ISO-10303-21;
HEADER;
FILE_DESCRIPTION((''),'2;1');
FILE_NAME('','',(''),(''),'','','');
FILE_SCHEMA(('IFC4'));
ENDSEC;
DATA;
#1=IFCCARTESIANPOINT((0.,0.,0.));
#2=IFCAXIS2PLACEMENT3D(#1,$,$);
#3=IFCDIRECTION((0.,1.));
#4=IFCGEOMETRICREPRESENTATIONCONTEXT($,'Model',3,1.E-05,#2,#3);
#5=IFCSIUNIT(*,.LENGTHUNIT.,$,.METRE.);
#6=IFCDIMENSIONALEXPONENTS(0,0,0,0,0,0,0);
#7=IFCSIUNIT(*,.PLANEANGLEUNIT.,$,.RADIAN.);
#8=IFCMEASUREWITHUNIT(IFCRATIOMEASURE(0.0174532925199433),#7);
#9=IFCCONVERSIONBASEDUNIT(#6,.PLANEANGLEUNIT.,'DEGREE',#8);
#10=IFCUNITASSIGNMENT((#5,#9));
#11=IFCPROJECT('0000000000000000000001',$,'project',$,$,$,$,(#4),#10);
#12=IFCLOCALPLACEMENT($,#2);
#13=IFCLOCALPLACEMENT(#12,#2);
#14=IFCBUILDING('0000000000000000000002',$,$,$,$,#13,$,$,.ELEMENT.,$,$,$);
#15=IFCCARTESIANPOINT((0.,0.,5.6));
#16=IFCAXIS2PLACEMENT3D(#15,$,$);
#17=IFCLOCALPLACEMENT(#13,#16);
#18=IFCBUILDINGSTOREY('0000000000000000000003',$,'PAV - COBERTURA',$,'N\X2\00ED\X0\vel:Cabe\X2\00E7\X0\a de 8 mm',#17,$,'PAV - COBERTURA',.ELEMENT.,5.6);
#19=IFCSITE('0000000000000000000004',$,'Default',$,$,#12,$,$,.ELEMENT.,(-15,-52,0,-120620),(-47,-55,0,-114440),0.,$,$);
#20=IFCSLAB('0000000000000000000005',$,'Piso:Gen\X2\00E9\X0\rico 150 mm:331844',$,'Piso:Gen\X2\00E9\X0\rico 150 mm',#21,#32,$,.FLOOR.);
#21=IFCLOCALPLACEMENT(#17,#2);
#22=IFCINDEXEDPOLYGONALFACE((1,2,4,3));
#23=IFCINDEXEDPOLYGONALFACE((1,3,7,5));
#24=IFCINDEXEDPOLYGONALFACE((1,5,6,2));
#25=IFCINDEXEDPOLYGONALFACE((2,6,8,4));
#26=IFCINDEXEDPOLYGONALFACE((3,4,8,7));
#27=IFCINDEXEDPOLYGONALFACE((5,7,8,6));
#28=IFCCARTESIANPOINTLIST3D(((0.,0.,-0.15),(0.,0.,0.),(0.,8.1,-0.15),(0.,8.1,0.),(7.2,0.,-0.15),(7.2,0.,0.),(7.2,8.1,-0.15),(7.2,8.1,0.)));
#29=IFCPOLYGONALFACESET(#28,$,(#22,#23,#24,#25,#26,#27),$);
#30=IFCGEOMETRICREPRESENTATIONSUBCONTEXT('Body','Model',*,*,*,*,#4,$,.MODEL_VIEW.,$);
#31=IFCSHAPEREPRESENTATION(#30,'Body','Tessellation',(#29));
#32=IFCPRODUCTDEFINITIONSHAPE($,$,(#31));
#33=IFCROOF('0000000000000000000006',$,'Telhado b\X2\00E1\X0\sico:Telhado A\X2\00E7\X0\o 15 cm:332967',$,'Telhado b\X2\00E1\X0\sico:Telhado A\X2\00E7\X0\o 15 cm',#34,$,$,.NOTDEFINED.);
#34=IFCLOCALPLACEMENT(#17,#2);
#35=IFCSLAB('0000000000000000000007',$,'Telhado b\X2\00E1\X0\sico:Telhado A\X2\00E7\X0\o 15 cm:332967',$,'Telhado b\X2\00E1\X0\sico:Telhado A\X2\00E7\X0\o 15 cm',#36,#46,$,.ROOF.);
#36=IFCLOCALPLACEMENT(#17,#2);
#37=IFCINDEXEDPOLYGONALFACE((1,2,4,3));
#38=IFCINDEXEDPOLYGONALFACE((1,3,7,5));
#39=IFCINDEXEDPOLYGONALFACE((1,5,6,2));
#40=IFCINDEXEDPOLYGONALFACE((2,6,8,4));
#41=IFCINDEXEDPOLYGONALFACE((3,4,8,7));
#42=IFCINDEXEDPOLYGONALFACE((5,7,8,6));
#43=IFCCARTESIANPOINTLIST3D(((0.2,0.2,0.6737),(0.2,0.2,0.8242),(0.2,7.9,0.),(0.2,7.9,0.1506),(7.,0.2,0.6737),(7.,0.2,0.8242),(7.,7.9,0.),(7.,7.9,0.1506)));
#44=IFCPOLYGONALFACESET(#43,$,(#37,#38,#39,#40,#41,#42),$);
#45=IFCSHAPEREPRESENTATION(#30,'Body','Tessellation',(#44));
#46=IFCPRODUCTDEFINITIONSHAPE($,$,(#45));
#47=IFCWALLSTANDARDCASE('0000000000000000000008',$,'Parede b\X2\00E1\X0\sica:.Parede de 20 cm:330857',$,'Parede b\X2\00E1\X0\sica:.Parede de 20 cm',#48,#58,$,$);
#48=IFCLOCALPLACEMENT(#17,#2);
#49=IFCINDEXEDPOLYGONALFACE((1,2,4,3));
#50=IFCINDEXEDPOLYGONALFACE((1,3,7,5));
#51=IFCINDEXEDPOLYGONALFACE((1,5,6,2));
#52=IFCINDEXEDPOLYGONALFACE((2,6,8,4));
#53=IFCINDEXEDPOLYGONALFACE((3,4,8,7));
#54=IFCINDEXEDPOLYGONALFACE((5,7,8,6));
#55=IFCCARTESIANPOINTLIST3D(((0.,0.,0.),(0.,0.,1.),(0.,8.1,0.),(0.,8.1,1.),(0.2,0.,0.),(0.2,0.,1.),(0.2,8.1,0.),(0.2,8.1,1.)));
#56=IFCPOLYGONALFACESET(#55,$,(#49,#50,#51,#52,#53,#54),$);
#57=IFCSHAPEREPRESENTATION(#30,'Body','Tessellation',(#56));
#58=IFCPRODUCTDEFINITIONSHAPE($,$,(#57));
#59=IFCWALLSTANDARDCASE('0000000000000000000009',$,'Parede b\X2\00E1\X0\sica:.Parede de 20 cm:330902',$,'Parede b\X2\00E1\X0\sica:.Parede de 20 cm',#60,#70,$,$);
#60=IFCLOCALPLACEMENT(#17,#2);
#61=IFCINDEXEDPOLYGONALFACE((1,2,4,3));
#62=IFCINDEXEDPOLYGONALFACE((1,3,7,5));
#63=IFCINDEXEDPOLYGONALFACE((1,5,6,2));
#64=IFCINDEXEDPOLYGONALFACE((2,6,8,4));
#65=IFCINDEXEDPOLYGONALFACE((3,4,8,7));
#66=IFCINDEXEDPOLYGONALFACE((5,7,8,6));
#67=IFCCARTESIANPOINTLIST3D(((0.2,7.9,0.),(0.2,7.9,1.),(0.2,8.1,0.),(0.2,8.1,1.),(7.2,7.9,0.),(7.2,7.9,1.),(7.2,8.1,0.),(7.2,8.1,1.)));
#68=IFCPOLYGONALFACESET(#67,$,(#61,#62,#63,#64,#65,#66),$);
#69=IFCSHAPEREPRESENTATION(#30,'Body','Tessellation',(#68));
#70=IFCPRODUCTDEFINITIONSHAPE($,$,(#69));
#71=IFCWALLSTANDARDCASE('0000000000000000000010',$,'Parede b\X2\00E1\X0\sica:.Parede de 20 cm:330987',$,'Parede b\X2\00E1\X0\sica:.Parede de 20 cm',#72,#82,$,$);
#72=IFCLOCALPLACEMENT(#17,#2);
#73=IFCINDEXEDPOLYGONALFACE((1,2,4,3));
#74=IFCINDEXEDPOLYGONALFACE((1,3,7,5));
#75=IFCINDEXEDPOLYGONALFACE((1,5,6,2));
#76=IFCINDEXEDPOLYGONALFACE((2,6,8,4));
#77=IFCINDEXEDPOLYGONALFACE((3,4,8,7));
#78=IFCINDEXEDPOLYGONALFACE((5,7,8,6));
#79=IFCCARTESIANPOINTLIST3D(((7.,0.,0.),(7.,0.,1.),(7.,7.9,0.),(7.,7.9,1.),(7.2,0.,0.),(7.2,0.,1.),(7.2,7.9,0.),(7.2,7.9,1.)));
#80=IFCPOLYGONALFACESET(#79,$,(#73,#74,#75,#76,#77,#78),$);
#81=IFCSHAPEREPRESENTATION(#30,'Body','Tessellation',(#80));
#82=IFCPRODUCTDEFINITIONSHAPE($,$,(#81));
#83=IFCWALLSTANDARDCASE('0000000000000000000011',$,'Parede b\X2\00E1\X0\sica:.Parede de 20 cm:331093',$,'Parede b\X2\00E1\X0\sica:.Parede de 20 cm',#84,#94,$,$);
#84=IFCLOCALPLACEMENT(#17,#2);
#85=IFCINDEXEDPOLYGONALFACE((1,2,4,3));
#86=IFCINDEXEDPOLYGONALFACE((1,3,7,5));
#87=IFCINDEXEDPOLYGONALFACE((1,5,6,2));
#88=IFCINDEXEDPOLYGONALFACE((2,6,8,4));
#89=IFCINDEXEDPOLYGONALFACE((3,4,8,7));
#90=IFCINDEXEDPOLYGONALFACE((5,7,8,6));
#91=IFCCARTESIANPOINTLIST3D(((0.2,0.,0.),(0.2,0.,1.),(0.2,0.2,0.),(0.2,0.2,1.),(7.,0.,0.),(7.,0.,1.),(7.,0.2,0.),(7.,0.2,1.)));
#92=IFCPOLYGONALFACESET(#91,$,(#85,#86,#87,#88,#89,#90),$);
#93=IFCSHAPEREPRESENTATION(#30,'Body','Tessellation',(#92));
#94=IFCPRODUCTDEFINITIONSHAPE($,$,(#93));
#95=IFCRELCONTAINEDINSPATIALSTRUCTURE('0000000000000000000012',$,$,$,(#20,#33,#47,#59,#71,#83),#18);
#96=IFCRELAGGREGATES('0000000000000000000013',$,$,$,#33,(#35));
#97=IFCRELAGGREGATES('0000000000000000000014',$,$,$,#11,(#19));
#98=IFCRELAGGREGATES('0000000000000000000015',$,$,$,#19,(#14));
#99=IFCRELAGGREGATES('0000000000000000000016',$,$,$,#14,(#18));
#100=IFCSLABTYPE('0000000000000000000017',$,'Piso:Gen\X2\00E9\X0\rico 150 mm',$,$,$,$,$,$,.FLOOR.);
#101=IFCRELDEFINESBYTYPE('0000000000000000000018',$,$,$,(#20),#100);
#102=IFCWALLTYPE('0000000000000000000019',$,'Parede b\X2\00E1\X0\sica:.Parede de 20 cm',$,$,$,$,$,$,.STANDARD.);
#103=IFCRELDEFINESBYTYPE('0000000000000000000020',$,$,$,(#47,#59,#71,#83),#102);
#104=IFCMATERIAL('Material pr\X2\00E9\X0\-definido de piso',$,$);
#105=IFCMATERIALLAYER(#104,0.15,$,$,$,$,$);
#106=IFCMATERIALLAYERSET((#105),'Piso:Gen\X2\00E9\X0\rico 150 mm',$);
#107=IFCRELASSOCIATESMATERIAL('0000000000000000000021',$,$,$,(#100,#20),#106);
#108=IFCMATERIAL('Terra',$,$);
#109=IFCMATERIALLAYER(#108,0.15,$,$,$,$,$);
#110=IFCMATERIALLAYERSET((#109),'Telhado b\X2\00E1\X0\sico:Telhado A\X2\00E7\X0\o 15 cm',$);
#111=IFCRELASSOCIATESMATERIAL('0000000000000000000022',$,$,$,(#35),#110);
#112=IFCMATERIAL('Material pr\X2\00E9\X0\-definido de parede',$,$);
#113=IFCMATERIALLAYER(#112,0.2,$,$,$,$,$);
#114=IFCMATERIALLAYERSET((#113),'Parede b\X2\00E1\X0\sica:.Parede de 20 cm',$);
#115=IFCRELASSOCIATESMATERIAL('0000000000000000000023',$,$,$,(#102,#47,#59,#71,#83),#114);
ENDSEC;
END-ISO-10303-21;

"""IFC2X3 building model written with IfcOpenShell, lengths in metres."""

from ifc_helpers import new_model, entity, si_unit, converted_unit, direction, frame, frame_2d, origin, origin_2d_with_axis, place, context, subcontext, project, spatial, rectangle, extrude, material, layer, layer_set, layer_usage, type_object, element, aggregate, save


model = new_model("IFC2X3")

# Units and contexts
model_context = context("Model", 3, precision=1e-05, world=origin(), true_north=direction((0.0, 1.0)))
body_context = subcontext(model_context, "Body", "Model", "MODEL_VIEW")
ifc_project = project(units=[si_unit("LENGTHUNIT", "METRE"), converted_unit("PLANEANGLEUNIT", "DEGREE", entity("IfcRatioMeasure", 0.0174532925199433), si_unit("PLANEANGLEUNIT", "RADIAN"), dimensions=[0, 0, 0, 0, 0, 0, 0])], contexts=[model_context])

# Site, building, storey
site_placement = place(None, origin())
site = spatial("IfcSite", under=ifc_project, at=site_placement, Name="Default", CompositionType="ELEMENT", RefLatitude=(-15, -52, 0, -120620), RefLongitude=(-47, -55, 0, -114440), RefElevation=0.0)
building_placement = place(site_placement, origin())
building = spatial("IfcBuilding", under=site, at=building_placement, CompositionType="ELEMENT")
storey_placement = place(building_placement, frame((0.0, 0.0, 5.6)))
storey = spatial("IfcBuildingStorey", under=building, at=storey_placement, Name="PAV - COBERTURA", ObjectType="Nível:Cabeça de 8 mm", LongName="PAV - COBERTURA", CompositionType="ELEMENT", Elevation=5.6)

# Slab
ifc_material_1 = material(Name="Material pré-definido de piso")
ifc_layer_1 = layer(ifc_material_1, 0.15)
ifc_layer_set_1 = layer_set([ifc_layer_1], Name="Piso:Genérico 150 mm")
ifc_layer_usage_1 = layer_usage(ifc_layer_set_1, "AXIS3", "POSITIVE", 0.0)
slab_type = type_object("IfcSlabType", Name="Piso:Genérico 150 mm", PredefinedType="FLOOR", material=ifc_layer_set_1)
slab_1_placement = place(storey_placement, origin())
element("IfcSlab", 1, at=slab_1_placement, inside=storey, type_object=slab_type, material=ifc_layer_usage_1, Name="Piso:Genérico 150 mm:331844", ObjectType="Piso:Genérico 150 mm", PredefinedType="FLOOR", context=body_context, shape_type="SweptSolid", body=[
    extrude(rectangle(XDim=8.1, YDim=7.2, at=frame_2d((0.0, 0.0), x_axis=(1.0, 0.0))), frame((3.6, 4.05, 0.0), z_axis=(0.0, 0.0, -1.0), x_axis=(0.0, 1.0, 0.0)), (0.0, 0.0, 1.0), 0.15),
])

# Roof, slab
roof_placement = place(storey_placement, frame((0.2, 0.2, 0.0)))
roof = element("IfcRoof", 2, at=roof_placement, inside=storey, Name="Telhado básico:Telhado Aço 15 cm:332967", ObjectType="Telhado básico:Telhado Aço 15 cm", ShapeType="NOTDEFINED")
ifc_material_2 = material(Name="Terra")
ifc_layer_2 = layer(ifc_material_2, 0.15)
ifc_layer_set_2 = layer_set([ifc_layer_2], Name="Telhado básico:Telhado Aço 15 cm")
slab_2_placement = place(roof_placement, origin())
slab_2 = element("IfcSlab", 3, at=slab_2_placement, material=ifc_layer_set_2, Name="Telhado básico:Telhado Aço 15 cm:332967", ObjectType="Telhado básico:Telhado Aço 15 cm", PredefinedType="ROOF", context=body_context, shape_type="SweptSolid", body=[
    extrude(rectangle(XDim=6.8, YDim=7.7294, at=origin_2d_with_axis()), frame((3.4, 3.85, 0.3368), z_axis=(0.0, 0.087156, 0.996195), x_axis=(1.0, 0.0, 0.0)), (0.0, -0.087156, 0.996195), 0.1506),
])
aggregate(roof, [slab_2])

# Walls
ifc_material_3 = material(Name="Material pré-definido de parede")
ifc_layer_3 = layer(ifc_material_3, 0.2)
ifc_layer_set_3 = layer_set([ifc_layer_3], Name="Parede básica:.Parede de 20 cm")
ifc_layer_usage_2 = layer_usage(ifc_layer_set_3, "AXIS2", "NEGATIVE", 0.1)
wall_type = type_object("IfcWallType", Name="Parede básica:.Parede de 20 cm", PredefinedType="STANDARD", material=ifc_layer_set_3)
wall_1_placement = place(storey_placement, frame((0.1, 0.0, 0.0), z_axis=(0.0, 0.0, 1.0), x_axis=(0.0, 1.0, 0.0)))
element("IfcWallStandardCase", 4, at=wall_1_placement, inside=storey, type_object=wall_type, material=ifc_layer_usage_2, Name="Parede básica:.Parede de 20 cm:330857", ObjectType="Parede básica:.Parede de 20 cm", context=body_context, shape_type="SweptSolid", body=[
    extrude(rectangle(XDim=8.1, YDim=0.2, at=frame_2d((4.05, 0.0), x_axis=(-1.0, 0.0))), origin(), (0.0, 0.0, 1.0), 1.0),
])
ifc_layer_usage_3 = layer_usage(ifc_layer_set_3, "AXIS2", "NEGATIVE", 0.1)
wall_2_placement = place(storey_placement, frame((0.2, 8.0, 0.0)))
element("IfcWallStandardCase", 5, at=wall_2_placement, inside=storey, type_object=wall_type, material=ifc_layer_usage_3, Name="Parede básica:.Parede de 20 cm:330902", ObjectType="Parede básica:.Parede de 20 cm", context=body_context, shape_type="SweptSolid", body=[
    extrude(rectangle(XDim=7.0, YDim=0.2, at=frame_2d((3.5, 0.0), x_axis=(-1.0, 0.0))), origin(), (0.0, 0.0, 1.0), 1.0),
])
ifc_layer_usage_4 = layer_usage(ifc_layer_set_3, "AXIS2", "NEGATIVE", 0.1)
wall_3_placement = place(storey_placement, frame((7.1, 7.9, 0.0), z_axis=(0.0, 0.0, 1.0), x_axis=(0.0, -1.0, 0.0)))
element("IfcWallStandardCase", 6, at=wall_3_placement, inside=storey, type_object=wall_type, material=ifc_layer_usage_4, Name="Parede básica:.Parede de 20 cm:330987", ObjectType="Parede básica:.Parede de 20 cm", context=body_context, shape_type="SweptSolid", body=[
    extrude(rectangle(XDim=7.9, YDim=0.2, at=frame_2d((3.95, 0.0), x_axis=(-1.0, 0.0))), origin(), (0.0, 0.0, 1.0), 1.0),
])
ifc_layer_usage_5 = layer_usage(ifc_layer_set_3, "AXIS2", "NEGATIVE", 0.1)
wall_4_placement = place(storey_placement, frame((7.0, 0.1, 0.0), z_axis=(0.0, 0.0, 1.0), x_axis=(-1.0, 0.0, 0.0)))
element("IfcWallStandardCase", 7, at=wall_4_placement, inside=storey, type_object=wall_type, material=ifc_layer_usage_5, Name="Parede básica:.Parede de 20 cm:331093", ObjectType="Parede básica:.Parede de 20 cm", context=body_context, shape_type="SweptSolid", body=[
    extrude(rectangle(XDim=6.8, YDim=0.2, at=frame_2d((3.4, 0.0), x_axis=(-1.0, 0.0))), origin(), (0.0, 0.0, 1.0), 1.0),
])

save(model, "model.ifc")
